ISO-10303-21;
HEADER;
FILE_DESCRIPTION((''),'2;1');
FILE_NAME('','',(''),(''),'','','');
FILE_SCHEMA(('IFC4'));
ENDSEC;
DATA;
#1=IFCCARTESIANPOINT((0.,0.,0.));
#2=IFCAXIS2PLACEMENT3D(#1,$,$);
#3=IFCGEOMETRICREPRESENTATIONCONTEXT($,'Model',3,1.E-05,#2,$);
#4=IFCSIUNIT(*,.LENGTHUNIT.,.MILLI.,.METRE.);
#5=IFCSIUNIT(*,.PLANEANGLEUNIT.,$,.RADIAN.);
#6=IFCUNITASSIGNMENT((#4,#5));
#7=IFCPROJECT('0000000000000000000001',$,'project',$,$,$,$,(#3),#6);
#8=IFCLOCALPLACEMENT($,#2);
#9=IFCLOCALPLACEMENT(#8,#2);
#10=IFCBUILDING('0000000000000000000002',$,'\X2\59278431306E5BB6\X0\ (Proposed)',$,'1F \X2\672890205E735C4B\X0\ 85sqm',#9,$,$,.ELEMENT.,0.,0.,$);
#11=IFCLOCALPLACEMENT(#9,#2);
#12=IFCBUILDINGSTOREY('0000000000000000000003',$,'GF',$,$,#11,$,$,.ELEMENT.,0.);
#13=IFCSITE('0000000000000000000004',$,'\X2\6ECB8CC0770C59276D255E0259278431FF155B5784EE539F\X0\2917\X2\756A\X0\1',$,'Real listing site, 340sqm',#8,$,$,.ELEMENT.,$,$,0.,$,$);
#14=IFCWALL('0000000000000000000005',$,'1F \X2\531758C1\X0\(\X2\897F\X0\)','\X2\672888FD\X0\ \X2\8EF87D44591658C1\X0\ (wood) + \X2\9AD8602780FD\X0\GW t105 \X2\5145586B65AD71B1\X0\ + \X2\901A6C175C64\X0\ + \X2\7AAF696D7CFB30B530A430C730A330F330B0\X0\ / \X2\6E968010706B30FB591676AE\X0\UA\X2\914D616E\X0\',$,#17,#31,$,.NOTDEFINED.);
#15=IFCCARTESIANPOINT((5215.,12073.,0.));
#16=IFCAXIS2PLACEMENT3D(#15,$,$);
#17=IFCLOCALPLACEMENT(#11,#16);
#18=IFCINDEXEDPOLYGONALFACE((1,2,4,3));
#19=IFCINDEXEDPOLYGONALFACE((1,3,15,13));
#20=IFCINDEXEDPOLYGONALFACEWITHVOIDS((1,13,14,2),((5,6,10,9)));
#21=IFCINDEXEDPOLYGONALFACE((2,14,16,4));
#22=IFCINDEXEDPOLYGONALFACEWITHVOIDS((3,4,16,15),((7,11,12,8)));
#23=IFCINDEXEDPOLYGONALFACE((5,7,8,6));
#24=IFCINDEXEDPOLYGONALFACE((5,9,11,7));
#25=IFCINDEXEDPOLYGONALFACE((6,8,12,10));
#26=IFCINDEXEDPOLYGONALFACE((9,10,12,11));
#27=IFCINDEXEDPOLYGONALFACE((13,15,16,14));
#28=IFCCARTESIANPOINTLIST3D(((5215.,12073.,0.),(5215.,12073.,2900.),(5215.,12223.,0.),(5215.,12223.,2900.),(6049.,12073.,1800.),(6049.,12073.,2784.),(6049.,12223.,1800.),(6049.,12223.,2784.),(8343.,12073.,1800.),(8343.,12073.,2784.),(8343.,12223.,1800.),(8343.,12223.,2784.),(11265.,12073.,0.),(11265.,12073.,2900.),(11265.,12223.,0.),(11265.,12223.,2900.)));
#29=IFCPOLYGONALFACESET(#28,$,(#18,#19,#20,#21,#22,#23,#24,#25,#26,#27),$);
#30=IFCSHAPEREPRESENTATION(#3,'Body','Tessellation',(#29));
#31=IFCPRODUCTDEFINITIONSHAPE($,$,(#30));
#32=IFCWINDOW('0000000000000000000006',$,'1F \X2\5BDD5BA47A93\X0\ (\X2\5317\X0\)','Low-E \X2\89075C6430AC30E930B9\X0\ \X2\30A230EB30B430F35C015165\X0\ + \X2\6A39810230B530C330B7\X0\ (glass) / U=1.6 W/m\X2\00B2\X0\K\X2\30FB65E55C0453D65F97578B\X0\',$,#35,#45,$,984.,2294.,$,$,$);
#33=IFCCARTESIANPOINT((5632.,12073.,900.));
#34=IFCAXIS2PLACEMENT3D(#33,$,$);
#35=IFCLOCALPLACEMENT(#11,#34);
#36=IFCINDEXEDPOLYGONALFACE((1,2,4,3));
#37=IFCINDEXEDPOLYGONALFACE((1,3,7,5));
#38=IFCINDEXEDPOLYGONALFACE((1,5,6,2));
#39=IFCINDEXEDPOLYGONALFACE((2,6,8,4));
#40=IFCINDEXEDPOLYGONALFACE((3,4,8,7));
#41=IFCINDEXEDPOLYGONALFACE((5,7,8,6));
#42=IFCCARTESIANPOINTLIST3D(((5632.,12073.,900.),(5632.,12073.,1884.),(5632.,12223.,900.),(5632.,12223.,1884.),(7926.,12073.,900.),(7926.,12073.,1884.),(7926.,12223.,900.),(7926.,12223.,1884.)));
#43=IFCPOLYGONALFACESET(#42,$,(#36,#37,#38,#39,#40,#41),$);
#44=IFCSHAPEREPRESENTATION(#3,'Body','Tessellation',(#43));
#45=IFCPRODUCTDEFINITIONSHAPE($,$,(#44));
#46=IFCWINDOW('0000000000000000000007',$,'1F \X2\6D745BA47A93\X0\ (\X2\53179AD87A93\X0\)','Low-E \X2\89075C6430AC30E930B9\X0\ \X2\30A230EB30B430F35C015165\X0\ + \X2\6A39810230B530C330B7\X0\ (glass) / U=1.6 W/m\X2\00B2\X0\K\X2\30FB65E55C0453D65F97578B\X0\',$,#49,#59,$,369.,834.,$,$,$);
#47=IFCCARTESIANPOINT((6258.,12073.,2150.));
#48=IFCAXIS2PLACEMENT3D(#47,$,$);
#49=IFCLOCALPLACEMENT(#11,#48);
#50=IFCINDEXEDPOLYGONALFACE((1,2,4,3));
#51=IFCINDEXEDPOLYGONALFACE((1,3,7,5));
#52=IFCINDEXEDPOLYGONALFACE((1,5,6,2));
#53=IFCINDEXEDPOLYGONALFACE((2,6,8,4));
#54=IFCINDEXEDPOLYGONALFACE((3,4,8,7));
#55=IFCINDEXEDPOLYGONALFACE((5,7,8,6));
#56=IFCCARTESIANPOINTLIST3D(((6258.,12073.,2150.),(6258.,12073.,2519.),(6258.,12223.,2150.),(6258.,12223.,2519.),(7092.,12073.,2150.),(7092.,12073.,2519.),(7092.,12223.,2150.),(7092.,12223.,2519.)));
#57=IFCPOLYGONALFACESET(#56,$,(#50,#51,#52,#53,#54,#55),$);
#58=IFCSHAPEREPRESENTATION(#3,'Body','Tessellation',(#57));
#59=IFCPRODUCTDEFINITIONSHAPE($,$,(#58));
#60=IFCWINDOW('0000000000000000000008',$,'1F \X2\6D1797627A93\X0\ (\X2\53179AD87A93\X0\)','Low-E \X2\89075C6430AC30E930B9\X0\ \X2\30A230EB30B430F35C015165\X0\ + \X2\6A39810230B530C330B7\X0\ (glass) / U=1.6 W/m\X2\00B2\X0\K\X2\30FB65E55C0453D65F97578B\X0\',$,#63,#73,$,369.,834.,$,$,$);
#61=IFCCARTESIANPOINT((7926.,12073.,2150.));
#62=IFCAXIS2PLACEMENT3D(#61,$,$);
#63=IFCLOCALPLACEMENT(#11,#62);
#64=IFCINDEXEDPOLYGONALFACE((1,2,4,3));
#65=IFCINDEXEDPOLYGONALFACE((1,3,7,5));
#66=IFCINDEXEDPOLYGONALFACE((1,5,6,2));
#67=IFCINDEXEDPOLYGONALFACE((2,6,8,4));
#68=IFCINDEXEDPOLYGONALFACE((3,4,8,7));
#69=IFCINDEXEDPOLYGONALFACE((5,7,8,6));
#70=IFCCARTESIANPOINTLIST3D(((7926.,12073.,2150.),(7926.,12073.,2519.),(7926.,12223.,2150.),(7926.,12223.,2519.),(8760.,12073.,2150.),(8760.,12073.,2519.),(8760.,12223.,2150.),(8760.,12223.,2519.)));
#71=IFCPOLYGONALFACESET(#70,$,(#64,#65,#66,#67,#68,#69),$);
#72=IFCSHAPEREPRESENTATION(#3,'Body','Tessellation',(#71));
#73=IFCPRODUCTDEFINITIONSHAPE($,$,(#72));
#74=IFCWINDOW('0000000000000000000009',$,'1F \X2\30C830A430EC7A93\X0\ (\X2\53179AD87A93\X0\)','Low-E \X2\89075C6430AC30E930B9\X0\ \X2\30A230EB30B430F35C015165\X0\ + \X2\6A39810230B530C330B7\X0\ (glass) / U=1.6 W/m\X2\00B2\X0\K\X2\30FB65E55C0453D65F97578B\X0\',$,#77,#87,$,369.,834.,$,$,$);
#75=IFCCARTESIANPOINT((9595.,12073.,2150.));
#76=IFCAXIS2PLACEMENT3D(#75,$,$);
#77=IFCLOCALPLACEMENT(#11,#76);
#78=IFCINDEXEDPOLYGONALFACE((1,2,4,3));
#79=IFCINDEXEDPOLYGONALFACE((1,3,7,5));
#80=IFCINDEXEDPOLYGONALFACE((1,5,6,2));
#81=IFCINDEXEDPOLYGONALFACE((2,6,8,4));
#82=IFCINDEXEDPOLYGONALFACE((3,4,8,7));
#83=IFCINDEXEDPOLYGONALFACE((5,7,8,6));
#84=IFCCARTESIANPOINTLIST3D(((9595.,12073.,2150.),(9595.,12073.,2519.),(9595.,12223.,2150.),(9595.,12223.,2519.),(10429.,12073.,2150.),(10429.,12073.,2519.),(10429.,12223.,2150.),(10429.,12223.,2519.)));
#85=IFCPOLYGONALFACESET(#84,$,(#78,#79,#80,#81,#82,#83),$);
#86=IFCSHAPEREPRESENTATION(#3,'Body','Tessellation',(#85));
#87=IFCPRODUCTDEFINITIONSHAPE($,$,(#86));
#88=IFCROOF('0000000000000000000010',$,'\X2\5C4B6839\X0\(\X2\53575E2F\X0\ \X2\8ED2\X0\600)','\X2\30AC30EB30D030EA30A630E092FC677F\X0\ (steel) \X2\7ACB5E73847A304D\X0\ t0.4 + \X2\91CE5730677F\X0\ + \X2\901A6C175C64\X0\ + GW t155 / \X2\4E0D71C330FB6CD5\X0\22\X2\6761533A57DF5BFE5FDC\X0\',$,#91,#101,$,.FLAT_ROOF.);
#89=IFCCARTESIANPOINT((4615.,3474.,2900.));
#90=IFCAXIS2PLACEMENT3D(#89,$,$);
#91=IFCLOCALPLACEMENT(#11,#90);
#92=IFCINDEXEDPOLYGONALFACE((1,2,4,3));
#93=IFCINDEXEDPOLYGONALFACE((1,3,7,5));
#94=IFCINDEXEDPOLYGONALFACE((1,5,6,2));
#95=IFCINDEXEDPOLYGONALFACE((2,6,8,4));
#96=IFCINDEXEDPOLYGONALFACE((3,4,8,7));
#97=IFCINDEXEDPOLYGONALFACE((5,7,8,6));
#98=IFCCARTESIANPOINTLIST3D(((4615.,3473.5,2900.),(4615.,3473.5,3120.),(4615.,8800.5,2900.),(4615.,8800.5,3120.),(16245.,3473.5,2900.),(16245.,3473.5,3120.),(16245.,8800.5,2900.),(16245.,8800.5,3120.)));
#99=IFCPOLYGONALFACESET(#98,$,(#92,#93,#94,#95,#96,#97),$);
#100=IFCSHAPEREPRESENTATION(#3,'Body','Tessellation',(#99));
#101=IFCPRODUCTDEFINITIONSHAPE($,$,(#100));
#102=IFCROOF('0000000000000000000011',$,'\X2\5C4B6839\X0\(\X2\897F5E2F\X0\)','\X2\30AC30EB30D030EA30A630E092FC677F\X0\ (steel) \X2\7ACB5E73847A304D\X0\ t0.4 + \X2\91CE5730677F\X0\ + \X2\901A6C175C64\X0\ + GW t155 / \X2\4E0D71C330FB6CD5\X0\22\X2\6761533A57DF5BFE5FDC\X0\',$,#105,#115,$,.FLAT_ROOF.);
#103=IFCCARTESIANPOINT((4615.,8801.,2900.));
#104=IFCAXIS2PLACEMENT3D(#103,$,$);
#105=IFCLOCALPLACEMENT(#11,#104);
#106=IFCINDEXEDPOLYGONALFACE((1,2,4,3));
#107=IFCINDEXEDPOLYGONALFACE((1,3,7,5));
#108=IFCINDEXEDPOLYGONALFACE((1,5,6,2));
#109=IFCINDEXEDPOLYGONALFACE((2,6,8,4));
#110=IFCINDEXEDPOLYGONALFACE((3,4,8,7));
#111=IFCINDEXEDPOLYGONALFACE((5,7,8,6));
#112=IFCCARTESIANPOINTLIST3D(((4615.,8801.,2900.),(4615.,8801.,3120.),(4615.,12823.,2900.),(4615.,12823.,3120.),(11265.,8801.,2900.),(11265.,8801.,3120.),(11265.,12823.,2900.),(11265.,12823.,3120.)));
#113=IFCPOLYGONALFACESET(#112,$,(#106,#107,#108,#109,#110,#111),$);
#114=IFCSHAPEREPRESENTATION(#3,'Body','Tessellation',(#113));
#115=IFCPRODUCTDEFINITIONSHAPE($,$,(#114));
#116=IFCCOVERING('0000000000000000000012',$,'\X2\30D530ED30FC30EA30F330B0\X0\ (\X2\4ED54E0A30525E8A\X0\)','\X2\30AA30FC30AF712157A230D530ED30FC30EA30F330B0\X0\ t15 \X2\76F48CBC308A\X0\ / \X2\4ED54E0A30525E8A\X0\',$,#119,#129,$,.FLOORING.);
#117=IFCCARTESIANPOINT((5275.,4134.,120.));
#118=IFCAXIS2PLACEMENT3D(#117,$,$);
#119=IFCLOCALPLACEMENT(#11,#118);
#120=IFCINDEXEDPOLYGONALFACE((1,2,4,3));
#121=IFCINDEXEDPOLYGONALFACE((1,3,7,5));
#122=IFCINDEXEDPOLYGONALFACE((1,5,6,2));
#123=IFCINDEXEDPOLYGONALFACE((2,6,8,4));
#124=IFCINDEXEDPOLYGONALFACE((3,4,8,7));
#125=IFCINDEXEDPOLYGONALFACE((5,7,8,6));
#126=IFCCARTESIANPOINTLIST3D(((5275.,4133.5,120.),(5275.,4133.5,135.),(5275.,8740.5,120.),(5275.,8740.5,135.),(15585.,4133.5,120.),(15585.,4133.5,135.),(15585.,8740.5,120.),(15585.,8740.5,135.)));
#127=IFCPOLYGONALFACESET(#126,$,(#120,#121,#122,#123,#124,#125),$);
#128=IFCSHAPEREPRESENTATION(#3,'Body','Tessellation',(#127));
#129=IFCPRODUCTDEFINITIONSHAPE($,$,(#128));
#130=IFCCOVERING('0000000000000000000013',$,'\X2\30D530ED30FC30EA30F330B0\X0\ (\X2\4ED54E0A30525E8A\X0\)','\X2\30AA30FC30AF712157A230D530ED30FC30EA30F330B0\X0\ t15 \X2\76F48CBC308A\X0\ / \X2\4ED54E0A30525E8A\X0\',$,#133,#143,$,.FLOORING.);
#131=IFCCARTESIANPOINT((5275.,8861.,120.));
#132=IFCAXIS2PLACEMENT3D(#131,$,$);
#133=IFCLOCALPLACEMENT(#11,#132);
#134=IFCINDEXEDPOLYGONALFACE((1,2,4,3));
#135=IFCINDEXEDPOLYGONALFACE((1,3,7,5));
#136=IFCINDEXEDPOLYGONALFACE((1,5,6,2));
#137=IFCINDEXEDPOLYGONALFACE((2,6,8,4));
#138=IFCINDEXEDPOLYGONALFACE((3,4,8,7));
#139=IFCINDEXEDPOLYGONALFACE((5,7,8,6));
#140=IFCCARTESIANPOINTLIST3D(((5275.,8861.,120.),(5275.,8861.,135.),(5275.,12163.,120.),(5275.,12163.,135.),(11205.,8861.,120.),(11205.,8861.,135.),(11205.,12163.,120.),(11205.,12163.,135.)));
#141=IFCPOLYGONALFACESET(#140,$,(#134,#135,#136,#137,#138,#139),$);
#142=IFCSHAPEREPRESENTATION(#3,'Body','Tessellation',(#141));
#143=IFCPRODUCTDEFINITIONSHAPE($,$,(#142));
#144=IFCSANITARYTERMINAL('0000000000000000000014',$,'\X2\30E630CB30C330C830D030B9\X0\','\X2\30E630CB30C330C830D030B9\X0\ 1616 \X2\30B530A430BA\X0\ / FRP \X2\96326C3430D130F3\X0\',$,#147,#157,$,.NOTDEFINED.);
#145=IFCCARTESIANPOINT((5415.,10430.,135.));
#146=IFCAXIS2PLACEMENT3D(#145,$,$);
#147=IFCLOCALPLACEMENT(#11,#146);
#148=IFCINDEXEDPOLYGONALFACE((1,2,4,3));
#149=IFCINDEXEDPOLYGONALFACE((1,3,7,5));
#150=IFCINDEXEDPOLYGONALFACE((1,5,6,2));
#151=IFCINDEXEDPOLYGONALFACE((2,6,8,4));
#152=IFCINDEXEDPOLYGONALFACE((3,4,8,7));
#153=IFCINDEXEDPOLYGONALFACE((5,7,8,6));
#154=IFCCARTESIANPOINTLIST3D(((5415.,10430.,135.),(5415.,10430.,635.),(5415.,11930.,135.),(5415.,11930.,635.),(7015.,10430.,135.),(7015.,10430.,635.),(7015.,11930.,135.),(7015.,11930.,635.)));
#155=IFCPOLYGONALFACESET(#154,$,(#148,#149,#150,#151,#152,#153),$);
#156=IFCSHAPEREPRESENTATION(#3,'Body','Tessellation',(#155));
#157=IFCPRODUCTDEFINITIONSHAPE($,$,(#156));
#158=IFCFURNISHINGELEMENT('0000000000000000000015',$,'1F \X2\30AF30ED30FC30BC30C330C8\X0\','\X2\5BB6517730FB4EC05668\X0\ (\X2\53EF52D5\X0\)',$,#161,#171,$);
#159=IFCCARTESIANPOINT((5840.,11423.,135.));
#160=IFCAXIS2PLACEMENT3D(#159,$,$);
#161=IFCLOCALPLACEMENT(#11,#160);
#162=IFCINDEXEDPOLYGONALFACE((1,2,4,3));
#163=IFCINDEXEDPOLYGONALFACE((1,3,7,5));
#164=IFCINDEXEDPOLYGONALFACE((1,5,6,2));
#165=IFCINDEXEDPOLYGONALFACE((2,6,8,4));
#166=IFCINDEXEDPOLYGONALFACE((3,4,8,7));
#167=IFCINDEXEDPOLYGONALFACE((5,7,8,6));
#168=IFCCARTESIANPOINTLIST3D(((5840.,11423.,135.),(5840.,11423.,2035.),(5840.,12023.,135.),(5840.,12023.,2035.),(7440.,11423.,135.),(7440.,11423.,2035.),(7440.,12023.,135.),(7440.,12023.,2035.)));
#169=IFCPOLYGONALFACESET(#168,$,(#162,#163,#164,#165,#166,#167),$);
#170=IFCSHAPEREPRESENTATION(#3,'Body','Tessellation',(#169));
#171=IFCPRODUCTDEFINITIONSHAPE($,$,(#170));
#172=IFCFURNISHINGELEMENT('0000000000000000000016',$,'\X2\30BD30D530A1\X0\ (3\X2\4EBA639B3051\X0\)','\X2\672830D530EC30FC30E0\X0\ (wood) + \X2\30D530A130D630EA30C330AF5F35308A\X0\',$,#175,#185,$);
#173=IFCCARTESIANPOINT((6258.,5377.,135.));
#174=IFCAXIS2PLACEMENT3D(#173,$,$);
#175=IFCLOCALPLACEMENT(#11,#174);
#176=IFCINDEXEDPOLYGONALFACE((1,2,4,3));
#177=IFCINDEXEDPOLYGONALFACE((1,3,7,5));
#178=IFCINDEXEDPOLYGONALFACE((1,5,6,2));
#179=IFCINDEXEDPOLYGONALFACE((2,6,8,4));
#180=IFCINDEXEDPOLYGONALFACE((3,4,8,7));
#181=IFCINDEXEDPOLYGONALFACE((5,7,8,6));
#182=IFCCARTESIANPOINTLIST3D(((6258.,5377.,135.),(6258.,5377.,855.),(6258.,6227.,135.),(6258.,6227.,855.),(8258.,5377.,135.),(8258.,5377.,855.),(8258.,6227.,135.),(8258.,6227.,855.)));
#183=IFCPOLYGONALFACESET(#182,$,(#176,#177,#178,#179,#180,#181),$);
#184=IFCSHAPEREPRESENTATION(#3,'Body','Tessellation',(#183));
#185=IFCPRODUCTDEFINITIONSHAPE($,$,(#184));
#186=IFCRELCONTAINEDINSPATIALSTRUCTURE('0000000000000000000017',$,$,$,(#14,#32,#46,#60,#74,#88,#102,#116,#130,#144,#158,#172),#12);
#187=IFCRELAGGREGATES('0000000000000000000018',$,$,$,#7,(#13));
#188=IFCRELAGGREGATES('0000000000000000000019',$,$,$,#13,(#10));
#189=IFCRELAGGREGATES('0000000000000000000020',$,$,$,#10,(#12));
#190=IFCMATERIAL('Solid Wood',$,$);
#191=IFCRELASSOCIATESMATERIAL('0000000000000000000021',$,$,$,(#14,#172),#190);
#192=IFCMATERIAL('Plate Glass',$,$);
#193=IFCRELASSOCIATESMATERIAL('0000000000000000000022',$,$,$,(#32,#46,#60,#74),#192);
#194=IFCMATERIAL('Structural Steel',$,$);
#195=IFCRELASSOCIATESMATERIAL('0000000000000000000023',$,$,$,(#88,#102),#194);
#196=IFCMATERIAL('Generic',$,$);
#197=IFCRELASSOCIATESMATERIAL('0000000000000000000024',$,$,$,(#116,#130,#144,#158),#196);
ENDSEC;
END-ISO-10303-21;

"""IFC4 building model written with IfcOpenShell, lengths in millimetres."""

from ifc_helpers import new_model, si_unit, frame, frame_2d, origin, place, context, project, spatial, rectangle, extrude, material, element, fill, save


model = new_model("IFC4")

# Units and contexts
model_context = context("Model", 3, precision=1e-05, world=origin())
ifc_project = project(units=[si_unit("LENGTHUNIT", "METRE", prefix="MILLI"), si_unit("PLANEANGLEUNIT", "RADIAN")], contexts=[model_context])

# Site, building, storey
site_placement = place(None, origin())
site = spatial("IfcSite", under=ifc_project, at=site_placement, Name="滋賀県大津市大萱５字蓮原2917番1", ObjectType="Real listing site, 340sqm", CompositionType="ELEMENT", RefElevation=0.0)
building_placement = place(site_placement, origin())
building = spatial("IfcBuilding", under=site, at=building_placement, Name="大萱の家 (Proposed)", ObjectType="1F 木造平屋 85sqm", CompositionType="ELEMENT", ElevationOfRefHeight=0.0, ElevationOfTerrain=0.0)
storey_placement = place(building_placement, origin())
storey = spatial("IfcBuildingStorey", under=building, at=storey_placement, Name="GF", CompositionType="ELEMENT", Elevation=0.0)

# Shared definitions
ifc_material_1 = material(Name="Solid Wood")

# Shared definitions
ifc_material_2 = material(Name="Plate Glass")

# Wall, openings, windows
wall_1_placement = place(storey_placement, frame((5215.0, 12073.0, 0.0)))
wall_1 = element("IfcWall", 1, at=wall_1_placement, inside=storey, material=ifc_material_1, Name="1F 北壁(西)", Description="木製 軸組外壁 (wood) + 高性能GW t105 充填断熱 + 通気層 + 窯業系サイディング / 準耐火・外皮UA配慮", PredefinedType="NOTDEFINED", context=model_context, shape_type="SweptSolid", body=[
    extrude(rectangle(XDim=6050.0, YDim=150.0, at=frame_2d((3025.0, 75.0))), frame((5215.0, 12073.0, 0.0)), (0.0, 0.0, 1.0), 2900.0),
])
opening_1_placement = place(storey_placement, frame((5632.0, 12073.0, 900.0)))
opening_1 = element("IfcOpeningElement", 2, at=opening_1_placement, cuts=wall_1, PredefinedType="NOTDEFINED", context=model_context, shape_type="SweptSolid", body=[
    extrude(rectangle(XDim=2294.0, YDim=150.0, at=frame_2d((1147.0, 75.0))), frame((5632.0, 12073.0, 900.0)), (0.0, 0.0, 1.0), 984.0),
])
opening_2_placement = place(storey_placement, frame((6258.0, 12073.0, 2150.0)))
opening_2 = element("IfcOpeningElement", 3, at=opening_2_placement, cuts=wall_1, PredefinedType="NOTDEFINED", context=model_context, shape_type="SweptSolid", body=[
    extrude(rectangle(XDim=834.0, YDim=150.0, at=frame_2d((417.0, 75.0))), frame((6258.0, 12073.0, 2150.0)), (0.0, 0.0, 1.0), 369.0),
])
opening_3_placement = place(storey_placement, frame((7926.0, 12073.0, 2150.0)))
opening_3 = element("IfcOpeningElement", 4, at=opening_3_placement, cuts=wall_1, PredefinedType="NOTDEFINED", context=model_context, shape_type="SweptSolid", body=[
    extrude(rectangle(XDim=834.0, YDim=150.0, at=frame_2d((417.0, 75.0))), frame((7926.0, 12073.0, 2150.0)), (0.0, 0.0, 1.0), 369.0),
])
opening_4_placement = place(storey_placement, frame((9595.0, 12073.0, 2150.0)))
opening_4 = element("IfcOpeningElement", 5, at=opening_4_placement, cuts=wall_1, PredefinedType="NOTDEFINED", context=model_context, shape_type="SweptSolid", body=[
    extrude(rectangle(XDim=834.0, YDim=150.0, at=frame_2d((417.0, 75.0))), frame((9595.0, 12073.0, 2150.0)), (0.0, 0.0, 1.0), 369.0),
])
window_1_placement = place(storey_placement, frame((5632.0, 12073.0, 900.0)))
window_1 = element("IfcWindow", 6, at=window_1_placement, inside=storey, material=ifc_material_2, Name="1F 寝室窓 (北)", Description="Low-E 複層ガラス アルゴン封入 + 樹脂サッシ (glass) / U=1.6 W/m²K・日射取得型", OverallHeight=984.0, OverallWidth=2294.0, context=model_context, shape_type="SweptSolid", body=[
    extrude(rectangle(XDim=2294.0, YDim=150.0, at=frame_2d((1147.0, 75.0))), frame((5632.0, 12073.0, 900.0)), (0.0, 0.0, 1.0), 984.0),
])
fill(opening_1, window_1)
window_2_placement = place(storey_placement, frame((6258.0, 12073.0, 2150.0)))
window_2 = element("IfcWindow", 7, at=window_2_placement, inside=storey, material=ifc_material_2, Name="1F 浴室窓 (北高窓)", Description="Low-E 複層ガラス アルゴン封入 + 樹脂サッシ (glass) / U=1.6 W/m²K・日射取得型", OverallHeight=369.0, OverallWidth=834.0, context=model_context, shape_type="SweptSolid", body=[
    extrude(rectangle(XDim=834.0, YDim=150.0, at=frame_2d((417.0, 75.0))), frame((6258.0, 12073.0, 2150.0)), (0.0, 0.0, 1.0), 369.0),
])
fill(opening_2, window_2)
window_3_placement = place(storey_placement, frame((7926.0, 12073.0, 2150.0)))
window_3 = element("IfcWindow", 8, at=window_3_placement, inside=storey, material=ifc_material_2, Name="1F 洗面窓 (北高窓)", Description="Low-E 複層ガラス アルゴン封入 + 樹脂サッシ (glass) / U=1.6 W/m²K・日射取得型", OverallHeight=369.0, OverallWidth=834.0, context=model_context, shape_type="SweptSolid", body=[
    extrude(rectangle(XDim=834.0, YDim=150.0, at=frame_2d((417.0, 75.0))), frame((7926.0, 12073.0, 2150.0)), (0.0, 0.0, 1.0), 369.0),
])
fill(opening_3, window_3)
window_4_placement = place(storey_placement, frame((9595.0, 12073.0, 2150.0)))
window_4 = element("IfcWindow", 9, at=window_4_placement, inside=storey, material=ifc_material_2, Name="1F トイレ窓 (北高窓)", Description="Low-E 複層ガラス アルゴン封入 + 樹脂サッシ (glass) / U=1.6 W/m²K・日射取得型", OverallHeight=369.0, OverallWidth=834.0, context=model_context, shape_type="SweptSolid", body=[
    extrude(rectangle(XDim=834.0, YDim=150.0, at=frame_2d((417.0, 75.0))), frame((9595.0, 12073.0, 2150.0)), (0.0, 0.0, 1.0), 369.0),
])
fill(opening_4, window_4)

# Roofs
ifc_material_3 = material(Name="Structural Steel")
roof_1_placement = place(storey_placement, frame((4615.0, 3474.0, 2900.0)))
element("IfcRoof", 10, at=roof_1_placement, inside=storey, material=ifc_material_3, Name="屋根(南帯 軒600)", Description="ガルバリウム鋼板 (steel) 立平葺き t0.4 + 野地板 + 通気層 + GW t155 / 不燃・法22条区域対応", PredefinedType="FLAT_ROOF", context=model_context, shape_type="SweptSolid", body=[
    extrude(rectangle(XDim=11630.0, YDim=5327.0, at=frame_2d((5815.0, 2663.0))), frame((4615.0, 3474.0, 2900.0)), (0.0, 0.0, 1.0), 220.0),
])
roof_2_placement = place(storey_placement, frame((4615.0, 8801.0, 2900.0)))
element("IfcRoof", 11, at=roof_2_placement, inside=storey, material=ifc_material_3, Name="屋根(西帯)", Description="ガルバリウム鋼板 (steel) 立平葺き t0.4 + 野地板 + 通気層 + GW t155 / 不燃・法22条区域対応", PredefinedType="FLAT_ROOF", context=model_context, shape_type="SweptSolid", body=[
    extrude(rectangle(XDim=6650.0, YDim=4022.0, at=frame_2d((3325.0, 2011.0))), frame((4615.0, 8801.0, 2900.0)), (0.0, 0.0, 1.0), 220.0),
])

# Coverings
ifc_material_4 = material(Name="Generic")
covering_1_placement = place(storey_placement, frame((5275.0, 4134.0, 120.0)))
element("IfcCovering", 12, at=covering_1_placement, inside=storey, material=ifc_material_4, Name="フローリング (仕上げ床)", Description="オーク無垢フローリング t15 直貼り / 仕上げ床", PredefinedType="FLOORING", context=model_context, shape_type="SweptSolid", body=[
    extrude(rectangle(XDim=10310.0, YDim=4607.0, at=frame_2d((5155.0, 2303.0))), frame((5275.0, 4134.0, 120.0)), (0.0, 0.0, 1.0), 15.0),
])
covering_2_placement = place(storey_placement, frame((5275.0, 8861.0, 120.0)))
element("IfcCovering", 13, at=covering_2_placement, inside=storey, material=ifc_material_4, Name="フローリング (仕上げ床)", Description="オーク無垢フローリング t15 直貼り / 仕上げ床", PredefinedType="FLOORING", context=model_context, shape_type="SweptSolid", body=[
    extrude(rectangle(XDim=5930.0, YDim=3302.0, at=frame_2d((2965.0, 1651.0))), frame((5275.0, 8861.0, 120.0)), (0.0, 0.0, 1.0), 15.0),
])

# Sanitary terminal
sanitary_terminal_placement = place(storey_placement, frame((5415.0, 10430.0, 135.0)))
element("IfcSanitaryTerminal", 14, at=sanitary_terminal_placement, inside=storey, material=ifc_material_4, Name="ユニットバス", Description="ユニットバス 1616 サイズ / FRP 防水パン", PredefinedType="NOTDEFINED", context=model_context, shape_type="SweptSolid", body=[
    extrude(rectangle(XDim=1600.0, YDim=1500.0, at=frame_2d((800.0, 750.0))), frame((5415.0, 10430.0, 135.0)), (0.0, 0.0, 1.0), 500.0),
])

# Furnishing elements
furnishing_1_placement = place(storey_placement, frame((5840.0, 11423.0, 135.0)))
element("IfcFurnishingElement", 15, at=furnishing_1_placement, inside=storey, material=ifc_material_4, Name="1F クローゼット", Description="家具・什器 (可動)", context=model_context, shape_type="SweptSolid", body=[
    extrude(rectangle(XDim=1600.0, YDim=600.0, at=frame_2d((800.0, 300.0))), frame((5840.0, 11423.0, 135.0)), (0.0, 0.0, 1.0), 1900.0),
])
furnishing_2_placement = place(storey_placement, frame((6258.0, 5377.0, 135.0)))
element("IfcFurnishingElement", 16, at=furnishing_2_placement, inside=storey, material=ifc_material_1, Name="ソファ (3人掛け)", Description="木フレーム (wood) + ファブリック張り", context=model_context, shape_type="SweptSolid", body=[
    extrude(rectangle(XDim=2000.0, YDim=850.0, at=frame_2d((1000.0, 425.0))), frame((6258.0, 5377.0, 135.0)), (0.0, 0.0, 1.0), 720.0),
])

save(model, "model.ifc")
